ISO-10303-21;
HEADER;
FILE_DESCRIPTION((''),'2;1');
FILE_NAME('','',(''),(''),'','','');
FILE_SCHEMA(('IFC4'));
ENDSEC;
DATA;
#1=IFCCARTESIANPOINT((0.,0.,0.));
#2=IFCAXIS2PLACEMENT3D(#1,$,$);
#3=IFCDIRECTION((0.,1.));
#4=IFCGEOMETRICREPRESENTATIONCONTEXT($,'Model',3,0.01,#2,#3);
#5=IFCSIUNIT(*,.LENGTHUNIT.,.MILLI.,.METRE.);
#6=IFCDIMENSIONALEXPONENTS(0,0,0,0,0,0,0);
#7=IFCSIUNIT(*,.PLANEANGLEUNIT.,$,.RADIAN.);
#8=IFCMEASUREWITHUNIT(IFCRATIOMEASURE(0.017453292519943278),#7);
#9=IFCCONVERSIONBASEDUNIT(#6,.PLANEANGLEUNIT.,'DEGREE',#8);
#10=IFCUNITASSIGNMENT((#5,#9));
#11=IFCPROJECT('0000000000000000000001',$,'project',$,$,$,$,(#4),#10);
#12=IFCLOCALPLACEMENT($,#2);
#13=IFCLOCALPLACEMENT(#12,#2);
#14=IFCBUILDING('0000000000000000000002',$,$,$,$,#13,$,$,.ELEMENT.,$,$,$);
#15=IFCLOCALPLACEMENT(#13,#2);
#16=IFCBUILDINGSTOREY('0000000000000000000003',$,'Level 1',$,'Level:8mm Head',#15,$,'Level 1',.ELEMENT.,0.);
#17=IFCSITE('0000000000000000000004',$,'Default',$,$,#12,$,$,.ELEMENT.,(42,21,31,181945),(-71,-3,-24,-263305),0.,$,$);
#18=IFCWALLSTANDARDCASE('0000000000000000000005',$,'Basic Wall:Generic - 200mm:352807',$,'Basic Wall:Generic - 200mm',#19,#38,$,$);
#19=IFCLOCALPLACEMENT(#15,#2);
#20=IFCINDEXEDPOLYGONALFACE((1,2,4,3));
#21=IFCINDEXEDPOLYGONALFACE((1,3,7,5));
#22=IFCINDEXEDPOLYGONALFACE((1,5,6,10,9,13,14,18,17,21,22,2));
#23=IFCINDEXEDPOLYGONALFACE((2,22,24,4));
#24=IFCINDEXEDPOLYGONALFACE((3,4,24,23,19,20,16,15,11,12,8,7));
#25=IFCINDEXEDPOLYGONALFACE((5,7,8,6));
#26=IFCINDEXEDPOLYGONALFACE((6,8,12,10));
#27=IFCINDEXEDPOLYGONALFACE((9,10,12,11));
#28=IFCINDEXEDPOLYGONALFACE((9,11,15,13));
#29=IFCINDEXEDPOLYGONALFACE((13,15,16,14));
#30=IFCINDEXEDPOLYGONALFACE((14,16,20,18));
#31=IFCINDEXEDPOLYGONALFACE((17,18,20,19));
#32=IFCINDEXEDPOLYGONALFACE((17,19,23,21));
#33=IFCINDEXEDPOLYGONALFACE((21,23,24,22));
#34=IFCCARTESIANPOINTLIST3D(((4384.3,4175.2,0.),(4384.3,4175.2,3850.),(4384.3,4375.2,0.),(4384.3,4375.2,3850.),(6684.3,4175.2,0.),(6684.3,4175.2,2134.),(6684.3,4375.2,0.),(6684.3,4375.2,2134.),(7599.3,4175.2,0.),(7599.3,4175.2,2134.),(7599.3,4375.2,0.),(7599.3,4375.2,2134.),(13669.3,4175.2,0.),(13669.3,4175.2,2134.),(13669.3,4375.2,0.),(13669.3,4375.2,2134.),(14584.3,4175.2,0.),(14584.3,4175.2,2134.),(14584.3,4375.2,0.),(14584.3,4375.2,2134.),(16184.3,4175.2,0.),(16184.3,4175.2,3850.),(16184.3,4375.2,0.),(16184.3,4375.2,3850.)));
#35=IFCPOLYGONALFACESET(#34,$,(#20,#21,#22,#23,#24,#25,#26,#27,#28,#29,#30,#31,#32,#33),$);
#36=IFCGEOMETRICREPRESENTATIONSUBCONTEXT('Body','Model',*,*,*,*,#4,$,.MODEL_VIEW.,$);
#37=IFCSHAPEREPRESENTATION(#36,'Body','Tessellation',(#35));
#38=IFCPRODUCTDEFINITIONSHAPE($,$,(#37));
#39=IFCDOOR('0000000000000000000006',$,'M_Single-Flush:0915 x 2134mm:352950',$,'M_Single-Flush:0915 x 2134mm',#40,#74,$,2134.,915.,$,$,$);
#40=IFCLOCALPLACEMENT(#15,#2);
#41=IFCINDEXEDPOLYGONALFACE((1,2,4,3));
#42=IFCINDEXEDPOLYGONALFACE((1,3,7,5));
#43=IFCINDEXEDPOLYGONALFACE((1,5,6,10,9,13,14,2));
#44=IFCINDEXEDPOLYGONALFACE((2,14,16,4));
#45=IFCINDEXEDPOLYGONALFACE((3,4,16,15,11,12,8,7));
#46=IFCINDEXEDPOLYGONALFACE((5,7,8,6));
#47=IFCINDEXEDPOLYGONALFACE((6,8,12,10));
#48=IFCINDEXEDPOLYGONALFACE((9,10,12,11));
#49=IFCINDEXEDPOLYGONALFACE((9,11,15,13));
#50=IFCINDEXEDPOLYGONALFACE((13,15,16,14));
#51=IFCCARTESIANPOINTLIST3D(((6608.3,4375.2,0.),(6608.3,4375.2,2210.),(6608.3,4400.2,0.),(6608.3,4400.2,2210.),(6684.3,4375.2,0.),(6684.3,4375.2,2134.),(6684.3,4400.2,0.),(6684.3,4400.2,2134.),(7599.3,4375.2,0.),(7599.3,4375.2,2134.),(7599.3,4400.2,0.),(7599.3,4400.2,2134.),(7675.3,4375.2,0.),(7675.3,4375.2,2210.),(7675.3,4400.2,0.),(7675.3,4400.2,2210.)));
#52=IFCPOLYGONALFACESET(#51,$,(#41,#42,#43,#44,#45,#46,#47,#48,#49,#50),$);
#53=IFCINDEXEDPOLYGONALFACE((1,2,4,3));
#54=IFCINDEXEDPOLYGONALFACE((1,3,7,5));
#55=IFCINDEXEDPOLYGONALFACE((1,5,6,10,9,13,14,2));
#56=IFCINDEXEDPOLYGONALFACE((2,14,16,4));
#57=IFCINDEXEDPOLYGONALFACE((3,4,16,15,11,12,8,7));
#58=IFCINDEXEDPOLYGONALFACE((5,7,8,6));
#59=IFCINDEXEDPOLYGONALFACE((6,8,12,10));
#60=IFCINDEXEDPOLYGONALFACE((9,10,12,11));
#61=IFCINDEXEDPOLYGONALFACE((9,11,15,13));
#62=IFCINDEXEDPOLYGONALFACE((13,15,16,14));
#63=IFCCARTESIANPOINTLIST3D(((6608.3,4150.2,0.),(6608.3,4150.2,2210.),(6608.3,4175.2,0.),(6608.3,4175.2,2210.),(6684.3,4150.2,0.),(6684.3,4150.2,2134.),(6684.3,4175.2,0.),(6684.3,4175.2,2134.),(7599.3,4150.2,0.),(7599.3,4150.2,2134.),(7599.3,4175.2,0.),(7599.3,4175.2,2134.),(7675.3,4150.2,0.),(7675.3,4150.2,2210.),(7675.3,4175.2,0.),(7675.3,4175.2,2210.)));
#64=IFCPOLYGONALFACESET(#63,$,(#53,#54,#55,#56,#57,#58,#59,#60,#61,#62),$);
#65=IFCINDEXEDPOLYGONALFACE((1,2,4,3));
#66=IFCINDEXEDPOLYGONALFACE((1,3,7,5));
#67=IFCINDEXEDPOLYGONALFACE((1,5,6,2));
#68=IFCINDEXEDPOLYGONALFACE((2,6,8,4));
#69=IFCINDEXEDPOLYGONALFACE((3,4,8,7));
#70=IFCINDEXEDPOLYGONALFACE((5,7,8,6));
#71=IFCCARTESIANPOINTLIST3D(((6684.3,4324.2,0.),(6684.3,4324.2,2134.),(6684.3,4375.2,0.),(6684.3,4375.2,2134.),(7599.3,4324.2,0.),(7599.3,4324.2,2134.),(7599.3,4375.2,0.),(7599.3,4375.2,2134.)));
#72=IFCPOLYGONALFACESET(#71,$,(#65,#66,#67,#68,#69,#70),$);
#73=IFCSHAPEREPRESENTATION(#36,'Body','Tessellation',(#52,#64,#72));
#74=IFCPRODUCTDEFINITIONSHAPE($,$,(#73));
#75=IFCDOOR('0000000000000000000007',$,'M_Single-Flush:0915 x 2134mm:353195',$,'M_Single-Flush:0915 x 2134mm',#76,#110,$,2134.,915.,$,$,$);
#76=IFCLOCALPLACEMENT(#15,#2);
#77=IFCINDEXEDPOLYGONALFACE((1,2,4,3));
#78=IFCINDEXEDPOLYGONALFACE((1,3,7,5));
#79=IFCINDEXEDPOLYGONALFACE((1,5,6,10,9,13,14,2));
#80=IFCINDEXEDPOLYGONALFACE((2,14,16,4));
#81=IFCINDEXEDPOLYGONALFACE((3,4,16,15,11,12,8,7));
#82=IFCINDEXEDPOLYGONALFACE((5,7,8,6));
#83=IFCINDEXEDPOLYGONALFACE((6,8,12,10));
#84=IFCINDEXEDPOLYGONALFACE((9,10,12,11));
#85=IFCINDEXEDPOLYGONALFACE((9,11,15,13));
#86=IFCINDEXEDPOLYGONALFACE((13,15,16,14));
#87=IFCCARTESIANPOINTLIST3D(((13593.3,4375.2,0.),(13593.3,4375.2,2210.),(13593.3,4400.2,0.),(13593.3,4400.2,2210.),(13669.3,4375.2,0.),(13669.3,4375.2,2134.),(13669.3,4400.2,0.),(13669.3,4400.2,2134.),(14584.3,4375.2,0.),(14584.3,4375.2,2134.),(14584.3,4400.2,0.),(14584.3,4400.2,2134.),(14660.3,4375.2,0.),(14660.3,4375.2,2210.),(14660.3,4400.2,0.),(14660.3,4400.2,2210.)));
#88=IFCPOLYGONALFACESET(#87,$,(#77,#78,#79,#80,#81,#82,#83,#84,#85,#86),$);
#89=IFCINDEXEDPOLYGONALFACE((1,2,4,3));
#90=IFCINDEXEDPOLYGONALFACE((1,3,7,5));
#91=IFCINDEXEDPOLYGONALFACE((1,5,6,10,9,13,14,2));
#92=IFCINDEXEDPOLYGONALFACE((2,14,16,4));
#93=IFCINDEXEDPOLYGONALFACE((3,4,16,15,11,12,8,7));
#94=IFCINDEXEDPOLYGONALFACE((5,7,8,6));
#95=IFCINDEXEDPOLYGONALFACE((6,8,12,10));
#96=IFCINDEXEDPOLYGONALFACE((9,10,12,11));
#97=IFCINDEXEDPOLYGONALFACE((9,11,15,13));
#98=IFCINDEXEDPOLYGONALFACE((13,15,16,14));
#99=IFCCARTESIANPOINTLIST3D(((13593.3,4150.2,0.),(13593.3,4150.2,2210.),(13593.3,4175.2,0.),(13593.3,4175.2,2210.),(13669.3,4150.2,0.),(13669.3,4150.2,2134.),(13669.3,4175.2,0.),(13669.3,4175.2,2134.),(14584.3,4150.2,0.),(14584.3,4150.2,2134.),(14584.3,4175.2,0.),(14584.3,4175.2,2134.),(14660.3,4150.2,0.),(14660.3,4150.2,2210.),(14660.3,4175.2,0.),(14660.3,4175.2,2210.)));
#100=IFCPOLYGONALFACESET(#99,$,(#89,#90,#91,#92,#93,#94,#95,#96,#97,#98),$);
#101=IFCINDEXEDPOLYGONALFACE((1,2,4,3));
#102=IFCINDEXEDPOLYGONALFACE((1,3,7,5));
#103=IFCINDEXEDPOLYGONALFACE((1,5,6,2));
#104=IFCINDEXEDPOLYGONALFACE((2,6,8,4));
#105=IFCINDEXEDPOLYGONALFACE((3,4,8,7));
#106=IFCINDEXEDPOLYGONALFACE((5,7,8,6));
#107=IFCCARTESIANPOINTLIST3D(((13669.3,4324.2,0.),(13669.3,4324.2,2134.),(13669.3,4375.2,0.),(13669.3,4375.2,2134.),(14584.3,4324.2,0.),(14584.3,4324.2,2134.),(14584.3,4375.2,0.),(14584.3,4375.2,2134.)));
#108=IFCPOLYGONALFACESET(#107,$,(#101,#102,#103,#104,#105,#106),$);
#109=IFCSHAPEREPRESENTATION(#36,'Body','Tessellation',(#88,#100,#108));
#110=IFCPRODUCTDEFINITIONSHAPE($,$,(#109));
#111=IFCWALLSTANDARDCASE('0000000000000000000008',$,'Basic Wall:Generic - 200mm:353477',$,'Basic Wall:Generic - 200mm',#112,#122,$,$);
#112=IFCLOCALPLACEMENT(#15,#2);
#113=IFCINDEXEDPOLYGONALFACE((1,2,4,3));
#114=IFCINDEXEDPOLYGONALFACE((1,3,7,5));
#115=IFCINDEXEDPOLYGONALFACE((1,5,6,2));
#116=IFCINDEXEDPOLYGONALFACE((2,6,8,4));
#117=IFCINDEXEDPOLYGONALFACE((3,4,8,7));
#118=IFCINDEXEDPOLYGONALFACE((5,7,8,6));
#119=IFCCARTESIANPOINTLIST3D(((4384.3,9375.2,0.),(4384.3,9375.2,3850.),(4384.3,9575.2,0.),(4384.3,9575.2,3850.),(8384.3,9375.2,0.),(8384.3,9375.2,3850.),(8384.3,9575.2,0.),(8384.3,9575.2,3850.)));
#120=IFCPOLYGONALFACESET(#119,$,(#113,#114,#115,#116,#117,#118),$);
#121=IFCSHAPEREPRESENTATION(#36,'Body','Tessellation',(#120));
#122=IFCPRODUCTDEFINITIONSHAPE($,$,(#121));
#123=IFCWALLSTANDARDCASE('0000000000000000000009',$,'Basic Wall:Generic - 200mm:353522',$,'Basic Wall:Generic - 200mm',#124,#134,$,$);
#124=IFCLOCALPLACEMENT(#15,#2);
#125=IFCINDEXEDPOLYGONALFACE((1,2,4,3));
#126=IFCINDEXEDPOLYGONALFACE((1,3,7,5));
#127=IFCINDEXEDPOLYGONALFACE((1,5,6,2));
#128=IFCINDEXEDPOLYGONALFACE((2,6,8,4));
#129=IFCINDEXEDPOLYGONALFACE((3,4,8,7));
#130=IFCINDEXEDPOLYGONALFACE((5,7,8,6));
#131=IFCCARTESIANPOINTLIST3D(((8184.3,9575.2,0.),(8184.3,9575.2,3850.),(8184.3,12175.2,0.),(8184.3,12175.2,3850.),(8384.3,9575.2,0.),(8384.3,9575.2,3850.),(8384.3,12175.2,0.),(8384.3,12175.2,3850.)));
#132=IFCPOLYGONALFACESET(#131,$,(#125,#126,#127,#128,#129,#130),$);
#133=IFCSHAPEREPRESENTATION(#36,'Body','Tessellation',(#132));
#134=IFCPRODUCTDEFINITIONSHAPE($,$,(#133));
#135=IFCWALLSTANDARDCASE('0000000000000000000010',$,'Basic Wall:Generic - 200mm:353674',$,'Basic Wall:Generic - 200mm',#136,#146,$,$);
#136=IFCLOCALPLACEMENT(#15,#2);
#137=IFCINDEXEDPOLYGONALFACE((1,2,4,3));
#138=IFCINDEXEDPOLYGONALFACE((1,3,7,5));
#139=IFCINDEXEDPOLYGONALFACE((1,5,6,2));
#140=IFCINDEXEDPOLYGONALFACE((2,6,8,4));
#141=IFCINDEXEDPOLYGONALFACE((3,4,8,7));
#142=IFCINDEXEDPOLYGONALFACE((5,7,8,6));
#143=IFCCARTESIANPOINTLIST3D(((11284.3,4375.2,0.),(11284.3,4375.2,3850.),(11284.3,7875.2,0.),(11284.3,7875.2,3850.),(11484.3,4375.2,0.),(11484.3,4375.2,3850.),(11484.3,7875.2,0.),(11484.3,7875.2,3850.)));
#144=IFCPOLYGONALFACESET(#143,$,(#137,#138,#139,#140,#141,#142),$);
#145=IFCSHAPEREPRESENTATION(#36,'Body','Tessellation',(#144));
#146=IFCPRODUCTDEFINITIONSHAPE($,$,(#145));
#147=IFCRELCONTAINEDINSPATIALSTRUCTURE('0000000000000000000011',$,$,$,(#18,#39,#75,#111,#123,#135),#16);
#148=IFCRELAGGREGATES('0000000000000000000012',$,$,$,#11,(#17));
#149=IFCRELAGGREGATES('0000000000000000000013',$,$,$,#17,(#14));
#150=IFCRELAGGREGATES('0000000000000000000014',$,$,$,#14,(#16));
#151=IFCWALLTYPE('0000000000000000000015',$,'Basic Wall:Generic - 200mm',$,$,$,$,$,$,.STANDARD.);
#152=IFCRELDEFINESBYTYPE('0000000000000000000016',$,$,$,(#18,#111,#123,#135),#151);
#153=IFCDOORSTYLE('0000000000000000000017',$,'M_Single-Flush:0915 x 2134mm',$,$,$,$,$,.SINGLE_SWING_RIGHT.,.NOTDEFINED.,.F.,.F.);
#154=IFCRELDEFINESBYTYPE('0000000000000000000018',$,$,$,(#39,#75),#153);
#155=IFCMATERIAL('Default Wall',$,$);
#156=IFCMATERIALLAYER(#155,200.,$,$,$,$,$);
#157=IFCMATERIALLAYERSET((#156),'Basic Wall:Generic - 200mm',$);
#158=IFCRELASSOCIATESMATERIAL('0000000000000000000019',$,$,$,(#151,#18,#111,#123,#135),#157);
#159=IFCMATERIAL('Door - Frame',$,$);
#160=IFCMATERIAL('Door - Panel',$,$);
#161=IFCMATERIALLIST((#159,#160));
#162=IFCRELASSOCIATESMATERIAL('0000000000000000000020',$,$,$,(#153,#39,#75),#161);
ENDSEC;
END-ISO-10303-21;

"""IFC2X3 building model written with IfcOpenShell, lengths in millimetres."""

from ifc_helpers import new_model, entity, si_unit, converted_unit, direction, frame, frame_2d, origin, place, context, subcontext, project, spatial, polyline, rectangle, outline, extrude, clip, bounded_halfspace, source, transform, mapped, material, material_list, layer, layer_set, layer_usage, type_object, type_shapes, element, fill, save


model = new_model("IFC2X3")

# Units and contexts
model_context = context("Model", 3, precision=0.01, world=origin(), true_north=direction((0.0, 1.0)))
body_context = subcontext(model_context, "Body", "Model", "MODEL_VIEW")
ifc_project = project(units=[si_unit("LENGTHUNIT", "METRE", prefix="MILLI"), converted_unit("PLANEANGLEUNIT", "DEGREE", entity("IfcRatioMeasure", 0.017453292519943278), si_unit("PLANEANGLEUNIT", "RADIAN"), dimensions=[0, 0, 0, 0, 0, 0, 0])], contexts=[model_context])

# Site, building, storey
site_placement = place(None, origin())
site = spatial("IfcSite", under=ifc_project, at=site_placement, Name="Default", CompositionType="ELEMENT", RefLatitude=(42, 21, 31, 181945), RefLongitude=(-71, -3, -24, -263305), RefElevation=0.0)
building_placement = place(site_placement, origin())
building = spatial("IfcBuilding", under=site, at=building_placement, CompositionType="ELEMENT")
storey_placement = place(building_placement, origin())
storey = spatial("IfcBuildingStorey", under=building, at=storey_placement, Name="Level 1", ObjectType="Level:8mm Head", LongName="Level 1", CompositionType="ELEMENT", Elevation=0.0)

# Shared definitions
ifc_material_1 = material(Name="Default Wall")
ifc_layer_1 = layer(ifc_material_1, 200.0)
ifc_layer_set_1 = layer_set([ifc_layer_1], Name="Basic Wall:Generic - 200mm")
ifc_layer_usage_1 = layer_usage(ifc_layer_set_1, "AXIS2", "NEGATIVE", 100.0)
wall_type = type_object("IfcWallType", Name="Basic Wall:Generic - 200mm", PredefinedType="STANDARD", material=ifc_layer_set_1)

# Wall, openings, doors
wall_1_placement = place(storey_placement, frame((16184.3, 4275.2, 0.0), z_axis=(0.0, 0.0, 1.0), x_axis=(-1.0, 0.0, 0.0)))
wall_1 = element("IfcWallStandardCase", 1, at=wall_1_placement, inside=storey, type_object=wall_type, material=ifc_layer_usage_1, Name="Basic Wall:Generic - 200mm:352807", ObjectType="Basic Wall:Generic - 200mm", context=body_context, shape_type="Clipping", body=[
    clip(extrude(rectangle(XDim=11800.0, YDim=200.0, at=frame_2d((5900.0, 0.0), x_axis=(1.0, 0.0))), origin(), (0.0, 0.0, 1.0), 3850.0), bounded_halfspace(frame((0.0, -100.0, 3850.0), z_axis=(0.0, 0.0, -1.0), x_axis=(-1.0, 0.0, 0.0)), True, frame((0.0, -100.0, 3850.0)), polyline([(0.0, 0.0), (4700.0, 0.0), (4900.0, 0.0), (11800.0, 0.0), (11800.0, 200.0), (0.0, 200.0), (0.0, 0.0)]))),
])
opening_1_placement = place(wall_1_placement, frame((9500.0, 100.0, 0.0)))
opening_1 = element("IfcOpeningElement", 2, at=opening_1_placement, cuts=wall_1, ObjectType="Opening", context=body_context, shape_type="SweptSolid", body=[
    extrude(rectangle(XDim=915.0, YDim=2134.0, at=frame_2d((1067.0, 457.5), x_axis=(0.0, 1.0))), frame((0.0, 0.0, 0.0), z_axis=(0.0, -1.0, 0.0), x_axis=(0.0, 0.0, 1.0)), (0.0, 0.0, 1.0), 200.0),
])
opening_2_placement = place(wall_1_placement, frame((2515.0, 100.0, 0.0)))
opening_2 = element("IfcOpeningElement", 3, at=opening_2_placement, cuts=wall_1, ObjectType="Opening", context=body_context, shape_type="SweptSolid", body=[
    extrude(rectangle(XDim=915.0, YDim=2134.0, at=frame_2d((1067.0, 457.5), x_axis=(0.0, 1.0))), frame((0.0, 0.0, 0.0), z_axis=(0.0, -1.0, 0.0), x_axis=(0.0, 0.0, 1.0)), (0.0, 0.0, 1.0), 200.0),
])
ifc_material_2 = material(Name="Door - Frame")
ifc_material_3 = material(Name="Door - Panel")
ifc_material_list = material_list([ifc_material_2, ifc_material_3])
door_style = type_object("IfcDoorStyle", Name="M_Single-Flush:0915 x 2134mm", ConstructionType="NOTDEFINED", OperationType="SINGLE_SWING_RIGHT", ParameterTakesPrecedence=False, Sizeable=False, material=ifc_material_list)
shared_shape = source(origin(), body_context, "Body", "SweptSolid", [
    extrude(outline(polyline([(-533.5, -1124.0), (533.5, -1124.0), (533.5, 1086.0), (457.5, 1086.0), (457.5, -1048.0), (-457.5, -1048.0), (-457.5, 1086.0), (-533.5, 1086.0), (-533.5, -1124.0)])), frame((457.5, 200.0, 1086.0), z_axis=(0.0, 1.0, 0.0), x_axis=(1.0, 0.0, 0.0)), (0.0, 0.0, 1.0), 25.0),
    extrude(outline(polyline([(-1124.0, -533.5), (1086.0, -533.5), (1086.0, -457.5), (-1048.0, -457.5), (-1048.0, 457.5), (1086.0, 457.5), (1086.0, 533.5), (-1124.0, 533.5), (-1124.0, -533.5)])), frame((457.5, -25.0, 1086.0), z_axis=(0.0, 1.0, 0.0), x_axis=(0.0, 0.0, -1.0)), (0.0, 0.0, 1.0), 25.0),
    extrude(rectangle(XDim=51.0, YDim=915.0, at=frame_2d((0.0, 0.0), x_axis=(1.0, 0.0))), frame((457.5, 174.5, 0.0), z_axis=(0.0, 0.0, 1.0), x_axis=(0.0, 1.0, 0.0)), (0.0, 0.0, 1.0), 2134.0),
])
type_shapes(door_style, [shared_shape])
door_1_placement = place(opening_1_placement, frame((0.0, 0.0, 0.0), z_axis=(0.0, 0.0, 1.0), x_axis=(-1.0, 0.0, 0.0)))
door_1 = element("IfcDoor", 4, at=door_1_placement, inside=storey, type_object=door_style, material=ifc_material_list, Name="M_Single-Flush:0915 x 2134mm:352950", ObjectType="M_Single-Flush:0915 x 2134mm", OverallHeight=2134.0, OverallWidth=915.0, context=body_context, shape_type="MappedRepresentation", body=[
    mapped(shared_shape, transform((0.0, 0.0, 0.0), scale=1.0)),
])
fill(opening_1, door_1)
door_2_placement = place(opening_2_placement, frame((0.0, 0.0, 0.0), z_axis=(0.0, 0.0, 1.0), x_axis=(-1.0, 0.0, 0.0)))
door_2 = element("IfcDoor", 5, at=door_2_placement, inside=storey, type_object=door_style, material=ifc_material_list, Name="M_Single-Flush:0915 x 2134mm:353195", ObjectType="M_Single-Flush:0915 x 2134mm", OverallHeight=2134.0, OverallWidth=915.0, context=body_context, shape_type="MappedRepresentation", body=[
    mapped(shared_shape, transform((0.0, 0.0, 0.0), scale=1.0)),
])
fill(opening_2, door_2)

# Walls
wall_2_placement = place(storey_placement, frame((4384.3, 9475.2, 0.0)))
element("IfcWallStandardCase", 6, at=wall_2_placement, inside=storey, type_object=wall_type, material=ifc_layer_usage_1, Name="Basic Wall:Generic - 200mm:353477", ObjectType="Basic Wall:Generic - 200mm", context=body_context, shape_type="Clipping", body=[
    clip(extrude(rectangle(XDim=4000.0, YDim=200.0, at=frame_2d((2000.0, 0.0), x_axis=(-1.0, 0.0))), origin(), (0.0, 0.0, 1.0), 3850.0), bounded_halfspace(frame((0.0, -100.0, 3850.0), z_axis=(0.0, 0.0, -1.0), x_axis=(1.0, 0.0, 0.0)), True, frame((0.0, -100.0, 3850.0)), polyline([(0.0, 0.0), (4000.0, 0.0), (4000.0, 200.0), (3800.0, 200.0), (0.0, 200.0), (0.0, 0.0)]))),
])
wall_3_placement = place(storey_placement, frame((8284.3, 9575.2, 0.0), z_axis=(0.0, 0.0, 1.0), x_axis=(0.0, 1.0, 0.0)))
element("IfcWallStandardCase", 7, at=wall_3_placement, inside=storey, type_object=wall_type, material=ifc_layer_usage_1, Name="Basic Wall:Generic - 200mm:353522", ObjectType="Basic Wall:Generic - 200mm", context=body_context, shape_type="Clipping", body=[
    clip(extrude(rectangle(XDim=2600.0, YDim=200.0, at=frame_2d((1300.0, 0.0), x_axis=(-1.0, 0.0))), origin(), (0.0, 0.0, 1.0), 3850.0), bounded_halfspace(frame((0.0, -100.0, 3850.0), z_axis=(0.0, 0.0, -1.0), x_axis=(0.0, -1.0, 0.0)), True, frame((0.0, -100.0, 3850.0)), polyline([(0.0, 0.0), (2600.0, 0.0), (2600.0, 200.0), (0.0, 200.0), (0.0, 0.0)]))),
])
wall_4_placement = place(storey_placement, frame((11384.3, 4375.2, 0.0), z_axis=(0.0, 0.0, 1.0), x_axis=(0.0, 1.0, 0.0)))
element("IfcWallStandardCase", 8, at=wall_4_placement, inside=storey, type_object=wall_type, material=ifc_layer_usage_1, Name="Basic Wall:Generic - 200mm:353674", ObjectType="Basic Wall:Generic - 200mm", context=body_context, shape_type="Clipping", body=[
    clip(extrude(rectangle(XDim=3500.0, YDim=200.0, at=frame_2d((1750.0, 0.0), x_axis=(-1.0, 0.0))), origin(), (0.0, 0.0, 1.0), 3850.0), bounded_halfspace(frame((0.0, -100.0, 3850.0), z_axis=(0.0, 0.0, -1.0), x_axis=(0.0, -1.0, 0.0)), True, frame((0.0, -100.0, 3850.0)), polyline([(0.0, 0.0), (3300.0, 0.0), (3500.0, 0.0), (3500.0, 200.0), (0.0, 200.0), (0.0, 0.0)]))),
])

save(model, "model.ifc")
